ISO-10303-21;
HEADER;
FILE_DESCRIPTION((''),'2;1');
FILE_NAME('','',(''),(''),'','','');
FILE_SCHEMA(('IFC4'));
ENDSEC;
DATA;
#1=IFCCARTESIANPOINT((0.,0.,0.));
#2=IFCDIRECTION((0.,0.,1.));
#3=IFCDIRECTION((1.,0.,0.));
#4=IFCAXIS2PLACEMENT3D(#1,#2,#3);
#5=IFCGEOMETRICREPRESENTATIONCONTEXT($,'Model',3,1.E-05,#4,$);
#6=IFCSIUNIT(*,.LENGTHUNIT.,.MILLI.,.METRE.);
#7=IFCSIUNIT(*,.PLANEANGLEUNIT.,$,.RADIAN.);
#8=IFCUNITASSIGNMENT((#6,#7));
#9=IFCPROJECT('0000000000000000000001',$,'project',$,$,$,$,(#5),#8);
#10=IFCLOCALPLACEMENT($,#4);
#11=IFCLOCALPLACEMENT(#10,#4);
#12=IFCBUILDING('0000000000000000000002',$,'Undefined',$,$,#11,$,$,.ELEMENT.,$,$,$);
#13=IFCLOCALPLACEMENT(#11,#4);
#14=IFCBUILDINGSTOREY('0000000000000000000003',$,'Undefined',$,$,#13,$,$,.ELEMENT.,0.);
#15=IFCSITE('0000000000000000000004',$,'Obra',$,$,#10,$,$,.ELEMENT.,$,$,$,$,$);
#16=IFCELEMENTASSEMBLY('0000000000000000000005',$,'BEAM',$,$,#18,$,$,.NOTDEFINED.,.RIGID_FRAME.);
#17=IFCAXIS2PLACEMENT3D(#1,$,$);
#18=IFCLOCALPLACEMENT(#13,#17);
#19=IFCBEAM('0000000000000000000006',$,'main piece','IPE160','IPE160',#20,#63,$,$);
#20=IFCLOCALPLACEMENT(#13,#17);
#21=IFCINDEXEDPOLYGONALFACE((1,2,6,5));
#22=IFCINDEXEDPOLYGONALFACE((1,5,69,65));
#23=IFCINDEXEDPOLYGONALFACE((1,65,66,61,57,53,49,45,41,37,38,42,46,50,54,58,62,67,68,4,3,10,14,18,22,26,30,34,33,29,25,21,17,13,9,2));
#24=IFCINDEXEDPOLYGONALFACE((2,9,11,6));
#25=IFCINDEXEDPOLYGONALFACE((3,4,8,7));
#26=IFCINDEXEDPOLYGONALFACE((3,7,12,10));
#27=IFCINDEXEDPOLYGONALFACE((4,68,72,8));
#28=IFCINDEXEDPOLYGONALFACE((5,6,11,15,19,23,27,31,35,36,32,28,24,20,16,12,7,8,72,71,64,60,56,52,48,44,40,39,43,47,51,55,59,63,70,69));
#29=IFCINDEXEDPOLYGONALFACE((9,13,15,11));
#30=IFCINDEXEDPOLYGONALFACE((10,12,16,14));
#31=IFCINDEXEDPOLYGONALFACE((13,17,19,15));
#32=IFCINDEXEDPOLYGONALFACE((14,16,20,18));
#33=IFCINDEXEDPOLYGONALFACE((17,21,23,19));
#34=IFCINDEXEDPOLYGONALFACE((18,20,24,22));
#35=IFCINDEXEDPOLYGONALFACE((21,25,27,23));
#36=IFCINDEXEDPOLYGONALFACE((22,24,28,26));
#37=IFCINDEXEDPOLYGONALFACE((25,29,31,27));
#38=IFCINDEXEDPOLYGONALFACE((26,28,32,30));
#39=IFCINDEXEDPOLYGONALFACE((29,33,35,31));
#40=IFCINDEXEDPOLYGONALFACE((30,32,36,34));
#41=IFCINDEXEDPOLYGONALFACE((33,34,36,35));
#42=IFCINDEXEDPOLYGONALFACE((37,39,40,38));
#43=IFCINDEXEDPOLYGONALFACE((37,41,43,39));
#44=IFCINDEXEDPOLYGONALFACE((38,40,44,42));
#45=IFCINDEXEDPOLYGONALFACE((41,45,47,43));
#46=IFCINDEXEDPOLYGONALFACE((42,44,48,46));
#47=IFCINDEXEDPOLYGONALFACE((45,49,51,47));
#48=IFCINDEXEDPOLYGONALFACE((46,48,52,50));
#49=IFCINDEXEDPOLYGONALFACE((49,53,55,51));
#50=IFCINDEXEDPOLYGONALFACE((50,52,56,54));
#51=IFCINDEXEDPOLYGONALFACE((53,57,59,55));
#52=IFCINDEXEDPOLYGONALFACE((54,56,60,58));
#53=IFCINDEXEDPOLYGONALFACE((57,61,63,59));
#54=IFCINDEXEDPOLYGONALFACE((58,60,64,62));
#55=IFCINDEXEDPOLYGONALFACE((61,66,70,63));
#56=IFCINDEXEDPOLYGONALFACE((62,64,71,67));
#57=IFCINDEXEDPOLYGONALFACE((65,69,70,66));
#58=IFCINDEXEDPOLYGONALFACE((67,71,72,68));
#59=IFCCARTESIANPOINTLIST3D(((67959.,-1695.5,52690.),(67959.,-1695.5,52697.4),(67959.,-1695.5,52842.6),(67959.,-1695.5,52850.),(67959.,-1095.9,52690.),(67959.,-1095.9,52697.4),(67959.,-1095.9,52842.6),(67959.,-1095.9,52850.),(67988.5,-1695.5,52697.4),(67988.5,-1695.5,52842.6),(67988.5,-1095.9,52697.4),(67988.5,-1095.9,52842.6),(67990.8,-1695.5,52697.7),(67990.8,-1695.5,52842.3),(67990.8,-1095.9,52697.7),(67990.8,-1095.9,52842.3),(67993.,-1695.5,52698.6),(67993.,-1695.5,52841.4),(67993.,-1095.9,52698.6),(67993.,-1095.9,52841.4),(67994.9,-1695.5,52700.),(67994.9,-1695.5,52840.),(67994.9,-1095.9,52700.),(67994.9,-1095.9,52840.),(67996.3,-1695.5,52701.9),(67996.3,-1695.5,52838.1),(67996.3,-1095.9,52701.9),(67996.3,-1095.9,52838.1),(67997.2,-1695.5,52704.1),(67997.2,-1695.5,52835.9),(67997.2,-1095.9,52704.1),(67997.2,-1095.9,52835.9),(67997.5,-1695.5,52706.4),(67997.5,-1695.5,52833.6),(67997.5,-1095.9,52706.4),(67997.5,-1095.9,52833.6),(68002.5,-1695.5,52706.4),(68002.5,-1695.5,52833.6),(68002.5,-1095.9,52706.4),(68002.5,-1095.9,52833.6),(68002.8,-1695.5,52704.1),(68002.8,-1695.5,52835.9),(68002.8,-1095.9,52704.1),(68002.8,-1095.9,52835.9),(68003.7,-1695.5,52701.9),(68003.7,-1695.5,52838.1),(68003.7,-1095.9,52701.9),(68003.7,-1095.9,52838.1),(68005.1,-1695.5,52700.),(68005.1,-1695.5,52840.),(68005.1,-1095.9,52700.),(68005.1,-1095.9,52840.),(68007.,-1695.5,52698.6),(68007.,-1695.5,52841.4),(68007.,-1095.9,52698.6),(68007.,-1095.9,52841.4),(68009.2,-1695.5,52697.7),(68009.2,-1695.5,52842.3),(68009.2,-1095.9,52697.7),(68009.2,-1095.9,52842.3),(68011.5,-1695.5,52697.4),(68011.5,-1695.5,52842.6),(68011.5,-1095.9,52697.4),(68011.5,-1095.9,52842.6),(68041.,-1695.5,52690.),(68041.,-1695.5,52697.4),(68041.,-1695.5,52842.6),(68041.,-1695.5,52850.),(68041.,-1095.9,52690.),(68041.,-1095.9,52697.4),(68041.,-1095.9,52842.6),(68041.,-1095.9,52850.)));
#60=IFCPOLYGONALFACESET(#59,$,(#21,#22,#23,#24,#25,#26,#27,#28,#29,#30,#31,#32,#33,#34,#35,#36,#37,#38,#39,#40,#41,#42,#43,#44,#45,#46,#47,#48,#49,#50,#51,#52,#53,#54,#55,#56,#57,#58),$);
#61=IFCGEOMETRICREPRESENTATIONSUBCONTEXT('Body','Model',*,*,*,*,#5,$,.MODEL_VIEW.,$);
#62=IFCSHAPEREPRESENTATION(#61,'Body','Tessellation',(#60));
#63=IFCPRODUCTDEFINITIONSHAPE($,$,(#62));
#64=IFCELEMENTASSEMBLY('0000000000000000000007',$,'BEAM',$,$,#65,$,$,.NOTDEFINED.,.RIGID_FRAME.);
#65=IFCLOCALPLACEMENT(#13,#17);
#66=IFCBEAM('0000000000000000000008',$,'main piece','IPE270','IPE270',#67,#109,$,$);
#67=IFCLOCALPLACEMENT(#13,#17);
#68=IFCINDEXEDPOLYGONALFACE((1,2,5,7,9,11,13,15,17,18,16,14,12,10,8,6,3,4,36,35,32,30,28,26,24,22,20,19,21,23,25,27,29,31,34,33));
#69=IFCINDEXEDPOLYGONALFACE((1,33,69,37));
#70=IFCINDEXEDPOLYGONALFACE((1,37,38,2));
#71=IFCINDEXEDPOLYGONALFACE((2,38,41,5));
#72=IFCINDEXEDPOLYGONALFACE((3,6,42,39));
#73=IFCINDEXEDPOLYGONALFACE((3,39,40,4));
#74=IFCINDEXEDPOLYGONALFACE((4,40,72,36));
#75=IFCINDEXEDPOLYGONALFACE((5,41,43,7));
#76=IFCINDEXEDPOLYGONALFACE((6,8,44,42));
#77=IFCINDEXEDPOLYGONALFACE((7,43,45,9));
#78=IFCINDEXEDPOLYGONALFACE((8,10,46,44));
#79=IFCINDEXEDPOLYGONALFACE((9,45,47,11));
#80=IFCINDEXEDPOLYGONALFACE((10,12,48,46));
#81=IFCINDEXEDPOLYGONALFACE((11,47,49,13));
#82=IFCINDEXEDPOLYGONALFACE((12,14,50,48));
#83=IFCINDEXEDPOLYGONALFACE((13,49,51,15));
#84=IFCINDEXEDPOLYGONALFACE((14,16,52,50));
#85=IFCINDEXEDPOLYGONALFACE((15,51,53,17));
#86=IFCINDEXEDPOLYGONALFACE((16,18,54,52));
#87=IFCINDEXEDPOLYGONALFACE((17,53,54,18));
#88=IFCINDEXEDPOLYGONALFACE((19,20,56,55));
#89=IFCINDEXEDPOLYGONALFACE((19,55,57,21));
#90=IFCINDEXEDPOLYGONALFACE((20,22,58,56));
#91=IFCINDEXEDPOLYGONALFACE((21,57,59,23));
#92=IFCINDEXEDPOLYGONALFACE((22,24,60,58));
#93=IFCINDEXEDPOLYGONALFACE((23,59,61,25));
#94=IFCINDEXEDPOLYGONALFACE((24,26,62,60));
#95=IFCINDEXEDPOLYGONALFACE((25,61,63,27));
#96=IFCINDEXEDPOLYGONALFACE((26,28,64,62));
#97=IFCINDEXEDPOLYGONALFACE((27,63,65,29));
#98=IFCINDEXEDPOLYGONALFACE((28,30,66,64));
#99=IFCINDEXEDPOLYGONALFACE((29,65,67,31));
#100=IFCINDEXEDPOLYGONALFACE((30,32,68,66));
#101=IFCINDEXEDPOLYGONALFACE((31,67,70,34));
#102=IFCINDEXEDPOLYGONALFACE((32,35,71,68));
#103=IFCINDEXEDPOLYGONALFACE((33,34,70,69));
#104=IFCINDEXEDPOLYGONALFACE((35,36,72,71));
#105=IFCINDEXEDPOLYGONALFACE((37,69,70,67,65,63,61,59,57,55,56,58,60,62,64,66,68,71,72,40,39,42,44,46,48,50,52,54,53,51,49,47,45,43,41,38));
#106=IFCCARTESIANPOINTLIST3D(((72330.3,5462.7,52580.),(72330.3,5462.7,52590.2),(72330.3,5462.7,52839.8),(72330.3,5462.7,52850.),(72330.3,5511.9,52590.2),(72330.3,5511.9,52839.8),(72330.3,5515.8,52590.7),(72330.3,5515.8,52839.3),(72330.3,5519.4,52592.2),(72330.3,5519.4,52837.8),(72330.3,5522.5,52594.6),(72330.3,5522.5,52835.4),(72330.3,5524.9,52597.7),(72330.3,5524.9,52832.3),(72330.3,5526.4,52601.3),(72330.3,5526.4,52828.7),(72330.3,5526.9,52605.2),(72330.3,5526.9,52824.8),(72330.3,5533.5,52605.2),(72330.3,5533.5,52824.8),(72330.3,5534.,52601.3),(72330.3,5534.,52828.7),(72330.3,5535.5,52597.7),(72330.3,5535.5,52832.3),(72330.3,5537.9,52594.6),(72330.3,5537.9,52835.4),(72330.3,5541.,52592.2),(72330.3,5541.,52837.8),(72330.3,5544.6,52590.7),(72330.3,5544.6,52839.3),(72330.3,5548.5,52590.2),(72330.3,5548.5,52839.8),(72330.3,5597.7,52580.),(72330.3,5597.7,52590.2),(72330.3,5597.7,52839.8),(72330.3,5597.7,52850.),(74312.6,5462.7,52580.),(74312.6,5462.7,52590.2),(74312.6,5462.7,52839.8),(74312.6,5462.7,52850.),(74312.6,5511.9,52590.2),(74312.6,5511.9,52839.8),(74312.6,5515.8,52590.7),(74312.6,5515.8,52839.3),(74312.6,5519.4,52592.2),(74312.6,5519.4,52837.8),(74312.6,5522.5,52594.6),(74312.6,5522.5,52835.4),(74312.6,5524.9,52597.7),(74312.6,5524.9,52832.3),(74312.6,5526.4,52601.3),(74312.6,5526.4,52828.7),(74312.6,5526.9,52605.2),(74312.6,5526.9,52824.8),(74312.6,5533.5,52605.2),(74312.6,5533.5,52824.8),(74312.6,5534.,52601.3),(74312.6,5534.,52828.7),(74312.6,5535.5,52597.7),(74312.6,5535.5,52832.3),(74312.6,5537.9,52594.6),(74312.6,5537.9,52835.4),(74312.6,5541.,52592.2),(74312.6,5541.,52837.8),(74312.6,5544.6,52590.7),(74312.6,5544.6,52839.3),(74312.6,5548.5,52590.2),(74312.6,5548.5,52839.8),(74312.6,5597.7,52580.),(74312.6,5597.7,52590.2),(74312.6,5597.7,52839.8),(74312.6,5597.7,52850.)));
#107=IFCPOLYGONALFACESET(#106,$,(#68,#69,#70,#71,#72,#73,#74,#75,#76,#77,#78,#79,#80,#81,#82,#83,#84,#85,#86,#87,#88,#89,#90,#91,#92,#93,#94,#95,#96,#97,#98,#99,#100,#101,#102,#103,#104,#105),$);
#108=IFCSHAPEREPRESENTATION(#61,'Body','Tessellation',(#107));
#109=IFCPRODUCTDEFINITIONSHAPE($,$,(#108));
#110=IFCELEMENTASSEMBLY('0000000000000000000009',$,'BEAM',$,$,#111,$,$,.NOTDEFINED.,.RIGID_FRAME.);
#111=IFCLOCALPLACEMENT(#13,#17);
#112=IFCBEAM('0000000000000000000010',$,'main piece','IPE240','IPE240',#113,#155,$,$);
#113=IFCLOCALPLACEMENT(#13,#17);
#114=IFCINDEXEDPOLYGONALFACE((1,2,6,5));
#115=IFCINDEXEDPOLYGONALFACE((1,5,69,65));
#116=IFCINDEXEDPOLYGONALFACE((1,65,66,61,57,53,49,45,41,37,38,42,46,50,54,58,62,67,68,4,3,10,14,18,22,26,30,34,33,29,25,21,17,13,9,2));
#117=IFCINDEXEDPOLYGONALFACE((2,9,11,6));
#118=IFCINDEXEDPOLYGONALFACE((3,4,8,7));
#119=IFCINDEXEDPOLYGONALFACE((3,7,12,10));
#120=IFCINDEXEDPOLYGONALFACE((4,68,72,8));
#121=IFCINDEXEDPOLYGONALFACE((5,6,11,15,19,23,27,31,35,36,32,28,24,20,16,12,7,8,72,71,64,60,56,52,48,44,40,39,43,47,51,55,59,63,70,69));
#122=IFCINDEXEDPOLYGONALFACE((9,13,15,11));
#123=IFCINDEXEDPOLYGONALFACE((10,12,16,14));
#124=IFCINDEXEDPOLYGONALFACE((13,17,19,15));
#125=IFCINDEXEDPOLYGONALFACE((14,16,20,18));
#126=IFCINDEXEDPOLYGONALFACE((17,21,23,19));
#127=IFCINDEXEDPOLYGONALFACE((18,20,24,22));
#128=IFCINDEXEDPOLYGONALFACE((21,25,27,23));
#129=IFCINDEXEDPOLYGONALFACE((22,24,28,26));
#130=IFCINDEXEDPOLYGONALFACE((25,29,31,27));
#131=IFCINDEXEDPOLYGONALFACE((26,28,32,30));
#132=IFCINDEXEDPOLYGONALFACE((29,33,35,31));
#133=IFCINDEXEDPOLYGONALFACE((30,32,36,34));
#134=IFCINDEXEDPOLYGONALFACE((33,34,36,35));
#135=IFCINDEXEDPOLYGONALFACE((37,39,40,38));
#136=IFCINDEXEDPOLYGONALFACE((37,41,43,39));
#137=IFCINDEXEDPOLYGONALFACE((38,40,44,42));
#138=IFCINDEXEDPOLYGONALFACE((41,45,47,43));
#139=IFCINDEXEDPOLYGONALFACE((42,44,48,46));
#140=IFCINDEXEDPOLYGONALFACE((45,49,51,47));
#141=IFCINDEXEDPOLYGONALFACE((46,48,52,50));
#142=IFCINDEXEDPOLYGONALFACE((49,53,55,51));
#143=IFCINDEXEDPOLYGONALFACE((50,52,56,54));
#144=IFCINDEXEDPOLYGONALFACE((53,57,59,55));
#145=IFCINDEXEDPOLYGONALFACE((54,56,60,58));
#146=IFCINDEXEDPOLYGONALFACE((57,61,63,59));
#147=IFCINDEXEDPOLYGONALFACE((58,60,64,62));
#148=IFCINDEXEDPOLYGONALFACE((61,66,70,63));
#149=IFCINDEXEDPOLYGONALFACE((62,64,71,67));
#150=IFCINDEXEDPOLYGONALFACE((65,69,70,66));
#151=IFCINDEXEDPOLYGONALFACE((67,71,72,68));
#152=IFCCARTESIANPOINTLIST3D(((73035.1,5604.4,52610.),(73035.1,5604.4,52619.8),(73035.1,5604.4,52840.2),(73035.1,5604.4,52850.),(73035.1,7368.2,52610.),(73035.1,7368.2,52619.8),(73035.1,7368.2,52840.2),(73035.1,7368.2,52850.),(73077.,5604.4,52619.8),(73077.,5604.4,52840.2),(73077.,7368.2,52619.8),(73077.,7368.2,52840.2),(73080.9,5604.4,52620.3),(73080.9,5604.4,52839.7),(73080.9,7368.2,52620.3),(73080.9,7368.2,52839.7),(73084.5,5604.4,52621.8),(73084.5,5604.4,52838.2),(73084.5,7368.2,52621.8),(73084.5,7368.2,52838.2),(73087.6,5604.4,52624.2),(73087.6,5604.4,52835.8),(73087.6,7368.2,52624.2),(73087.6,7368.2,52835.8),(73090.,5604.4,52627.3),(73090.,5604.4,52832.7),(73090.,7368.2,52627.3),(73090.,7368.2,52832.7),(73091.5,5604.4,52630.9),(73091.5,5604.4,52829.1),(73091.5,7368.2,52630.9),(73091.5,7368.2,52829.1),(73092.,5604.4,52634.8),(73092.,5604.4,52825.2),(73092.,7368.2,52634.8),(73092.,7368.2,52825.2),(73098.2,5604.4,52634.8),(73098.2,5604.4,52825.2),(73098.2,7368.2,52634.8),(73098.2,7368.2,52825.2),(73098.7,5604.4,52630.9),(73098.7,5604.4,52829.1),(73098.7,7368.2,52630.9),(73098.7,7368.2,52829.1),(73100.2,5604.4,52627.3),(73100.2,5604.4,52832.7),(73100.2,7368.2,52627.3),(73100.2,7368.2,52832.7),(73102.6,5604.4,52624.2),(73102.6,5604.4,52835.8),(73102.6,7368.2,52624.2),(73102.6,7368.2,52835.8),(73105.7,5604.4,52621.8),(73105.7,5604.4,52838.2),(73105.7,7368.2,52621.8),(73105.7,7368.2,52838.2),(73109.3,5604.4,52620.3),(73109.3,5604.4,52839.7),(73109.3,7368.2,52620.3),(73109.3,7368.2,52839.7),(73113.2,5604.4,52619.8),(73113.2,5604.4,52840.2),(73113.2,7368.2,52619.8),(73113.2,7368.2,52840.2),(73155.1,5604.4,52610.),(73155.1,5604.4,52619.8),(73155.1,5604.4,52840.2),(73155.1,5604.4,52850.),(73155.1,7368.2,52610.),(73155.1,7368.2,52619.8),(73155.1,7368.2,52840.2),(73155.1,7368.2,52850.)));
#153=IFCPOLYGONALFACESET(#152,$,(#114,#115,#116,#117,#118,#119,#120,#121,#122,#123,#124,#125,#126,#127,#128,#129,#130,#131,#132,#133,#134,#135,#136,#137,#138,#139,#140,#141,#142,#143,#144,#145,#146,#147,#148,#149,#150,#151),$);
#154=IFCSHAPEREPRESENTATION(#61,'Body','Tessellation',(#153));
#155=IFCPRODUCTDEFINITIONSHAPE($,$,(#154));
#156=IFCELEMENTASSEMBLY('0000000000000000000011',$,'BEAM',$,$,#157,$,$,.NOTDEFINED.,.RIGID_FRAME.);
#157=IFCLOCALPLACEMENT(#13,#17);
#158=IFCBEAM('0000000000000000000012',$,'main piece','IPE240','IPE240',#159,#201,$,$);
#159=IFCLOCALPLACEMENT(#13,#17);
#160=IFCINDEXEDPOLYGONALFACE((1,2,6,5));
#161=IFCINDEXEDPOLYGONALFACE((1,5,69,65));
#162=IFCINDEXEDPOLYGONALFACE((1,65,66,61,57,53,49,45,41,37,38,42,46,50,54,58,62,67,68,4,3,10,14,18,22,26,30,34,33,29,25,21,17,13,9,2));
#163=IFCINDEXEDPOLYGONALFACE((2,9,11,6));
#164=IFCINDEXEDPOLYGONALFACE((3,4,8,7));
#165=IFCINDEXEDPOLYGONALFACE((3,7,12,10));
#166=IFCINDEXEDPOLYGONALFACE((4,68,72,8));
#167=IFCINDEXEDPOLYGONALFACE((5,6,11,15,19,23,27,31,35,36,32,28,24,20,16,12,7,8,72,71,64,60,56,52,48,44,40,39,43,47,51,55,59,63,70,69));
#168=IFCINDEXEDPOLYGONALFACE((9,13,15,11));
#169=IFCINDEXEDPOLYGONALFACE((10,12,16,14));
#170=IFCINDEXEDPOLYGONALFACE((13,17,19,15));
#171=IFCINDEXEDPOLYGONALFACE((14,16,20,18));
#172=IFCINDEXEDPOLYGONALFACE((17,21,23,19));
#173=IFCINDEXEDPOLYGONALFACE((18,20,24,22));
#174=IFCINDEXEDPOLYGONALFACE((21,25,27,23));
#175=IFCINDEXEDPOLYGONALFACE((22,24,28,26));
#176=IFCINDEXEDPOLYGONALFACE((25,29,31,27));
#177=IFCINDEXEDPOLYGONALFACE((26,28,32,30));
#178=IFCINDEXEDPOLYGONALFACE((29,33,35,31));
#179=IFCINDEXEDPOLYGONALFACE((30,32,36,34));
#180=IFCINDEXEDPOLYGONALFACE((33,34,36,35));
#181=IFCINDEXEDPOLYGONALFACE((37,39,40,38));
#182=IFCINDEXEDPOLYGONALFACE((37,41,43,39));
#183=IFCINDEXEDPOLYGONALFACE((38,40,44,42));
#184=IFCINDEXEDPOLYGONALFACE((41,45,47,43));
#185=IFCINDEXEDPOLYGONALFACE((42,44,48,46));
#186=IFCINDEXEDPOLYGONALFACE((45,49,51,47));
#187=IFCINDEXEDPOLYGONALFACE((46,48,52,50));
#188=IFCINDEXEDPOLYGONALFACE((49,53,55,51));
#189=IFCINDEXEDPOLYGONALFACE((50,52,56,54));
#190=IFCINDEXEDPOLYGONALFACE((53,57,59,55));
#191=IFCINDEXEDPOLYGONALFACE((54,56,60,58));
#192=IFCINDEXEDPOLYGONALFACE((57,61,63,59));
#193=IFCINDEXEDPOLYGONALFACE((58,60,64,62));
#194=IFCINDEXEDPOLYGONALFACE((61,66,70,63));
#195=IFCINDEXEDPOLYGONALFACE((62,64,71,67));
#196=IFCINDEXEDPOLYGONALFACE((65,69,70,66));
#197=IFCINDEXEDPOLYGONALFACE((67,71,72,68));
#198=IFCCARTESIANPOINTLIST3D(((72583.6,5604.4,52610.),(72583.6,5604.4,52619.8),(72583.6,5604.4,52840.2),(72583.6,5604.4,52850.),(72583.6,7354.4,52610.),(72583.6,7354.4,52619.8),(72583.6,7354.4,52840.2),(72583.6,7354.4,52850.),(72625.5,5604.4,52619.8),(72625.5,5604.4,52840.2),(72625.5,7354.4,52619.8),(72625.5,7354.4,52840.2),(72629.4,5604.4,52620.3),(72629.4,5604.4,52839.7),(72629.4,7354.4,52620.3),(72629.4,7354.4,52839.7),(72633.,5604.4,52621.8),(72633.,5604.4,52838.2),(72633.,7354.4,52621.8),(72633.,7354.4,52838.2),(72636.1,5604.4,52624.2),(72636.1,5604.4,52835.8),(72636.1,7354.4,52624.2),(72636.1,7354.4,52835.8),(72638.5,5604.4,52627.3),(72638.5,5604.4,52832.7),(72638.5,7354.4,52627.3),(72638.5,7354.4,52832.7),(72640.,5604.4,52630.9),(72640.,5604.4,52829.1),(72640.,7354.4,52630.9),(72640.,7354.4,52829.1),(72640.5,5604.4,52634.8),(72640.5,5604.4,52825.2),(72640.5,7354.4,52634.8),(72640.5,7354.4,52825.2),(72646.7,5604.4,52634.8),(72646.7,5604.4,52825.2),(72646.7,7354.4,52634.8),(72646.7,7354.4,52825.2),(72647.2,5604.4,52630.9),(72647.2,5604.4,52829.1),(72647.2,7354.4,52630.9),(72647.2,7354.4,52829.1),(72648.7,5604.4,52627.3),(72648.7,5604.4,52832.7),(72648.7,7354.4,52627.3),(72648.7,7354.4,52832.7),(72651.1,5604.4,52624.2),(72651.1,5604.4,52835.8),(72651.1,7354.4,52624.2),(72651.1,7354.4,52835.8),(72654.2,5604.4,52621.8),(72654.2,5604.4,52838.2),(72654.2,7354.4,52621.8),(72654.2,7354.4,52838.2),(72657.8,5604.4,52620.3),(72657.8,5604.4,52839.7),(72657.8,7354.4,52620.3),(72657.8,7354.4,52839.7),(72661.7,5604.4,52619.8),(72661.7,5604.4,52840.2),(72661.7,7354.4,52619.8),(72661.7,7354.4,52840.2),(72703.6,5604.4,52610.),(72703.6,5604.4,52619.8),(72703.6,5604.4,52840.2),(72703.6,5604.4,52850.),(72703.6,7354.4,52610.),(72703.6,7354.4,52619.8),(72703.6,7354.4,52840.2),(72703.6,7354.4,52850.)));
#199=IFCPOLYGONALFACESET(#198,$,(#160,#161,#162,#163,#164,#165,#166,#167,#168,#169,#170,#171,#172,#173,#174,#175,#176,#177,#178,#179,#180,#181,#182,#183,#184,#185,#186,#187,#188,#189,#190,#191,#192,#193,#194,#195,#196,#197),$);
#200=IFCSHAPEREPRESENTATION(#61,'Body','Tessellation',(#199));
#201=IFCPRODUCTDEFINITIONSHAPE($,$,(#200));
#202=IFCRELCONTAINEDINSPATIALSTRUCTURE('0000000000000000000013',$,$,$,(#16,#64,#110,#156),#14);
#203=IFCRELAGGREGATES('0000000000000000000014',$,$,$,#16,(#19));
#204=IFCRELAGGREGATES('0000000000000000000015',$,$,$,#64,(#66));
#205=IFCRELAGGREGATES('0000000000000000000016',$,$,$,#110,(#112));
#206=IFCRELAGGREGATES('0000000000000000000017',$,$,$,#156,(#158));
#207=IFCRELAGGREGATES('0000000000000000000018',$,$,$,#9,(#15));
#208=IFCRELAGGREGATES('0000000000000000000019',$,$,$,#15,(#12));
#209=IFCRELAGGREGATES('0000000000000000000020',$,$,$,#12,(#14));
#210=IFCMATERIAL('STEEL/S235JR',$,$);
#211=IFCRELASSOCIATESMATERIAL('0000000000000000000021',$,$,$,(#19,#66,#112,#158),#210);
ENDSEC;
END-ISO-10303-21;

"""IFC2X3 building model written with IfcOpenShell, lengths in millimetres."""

from ifc_helpers import new_model, si_unit, frame, origin_with_axes, origin_2d_with_axis, place, context, subcontext, project, spatial, i_section, extrude, material, element, aggregate, save


model = new_model("IFC2X3")

# Units and contexts
model_context = context("Model", 3, precision=1e-05, world=origin_with_axes())
body_context = subcontext(model_context, "Body", "Model", "MODEL_VIEW")
ifc_project = project(units=[si_unit("LENGTHUNIT", "METRE", prefix="MILLI"), si_unit("PLANEANGLEUNIT", "RADIAN")], contexts=[model_context])

# Site, building, storey
site_placement = place(None, origin_with_axes())
site = spatial("IfcSite", under=ifc_project, at=site_placement, Name="Obra", CompositionType="ELEMENT")
building_placement = place(site_placement, origin_with_axes())
building = spatial("IfcBuilding", under=site, at=building_placement, Name="Undefined", CompositionType="ELEMENT")
storey_placement = place(building_placement, origin_with_axes())
storey = spatial("IfcBuildingStorey", under=building, at=storey_placement, Name="Undefined", CompositionType="ELEMENT", Elevation=0.0)

# Shared definitions
ifc_material_1 = material(Name="STEEL/S235JR")

# Element assemblies, beams
assembly_1_placement = place(storey_placement, origin_with_axes())
assembly_1 = element("IfcElementAssembly", 1, at=assembly_1_placement, inside=storey, Name="BEAM", AssemblyPlace="NOTDEFINED", PredefinedType="RIGID_FRAME")
beam_1_placement = place(assembly_1_placement, frame((68000.0, -1095.9, 52770.0), z_axis=(0.0, 0.0, 1.0), x_axis=(0.0, -1.0, 0.0)))
beam_1 = element("IfcBeam", 2, at=beam_1_placement, material=ifc_material_1, Name="main piece", Description="IPE160", ObjectType="IPE160", context=body_context, shape_type="SweptSolid", body=[
    extrude(i_section(OverallWidth=82.0, OverallDepth=160.0, WebThickness=5.0, FlangeThickness=7.4, FilletRadius=9.0, at=origin_2d_with_axis()), frame((599.6, 0.0, 0.0), z_axis=(-1.0, 0.0, 0.0), x_axis=(0.0, -1.0, 0.0)), (0.0, 0.0, 1.0), 599.6),
])
aggregate(assembly_1, [beam_1])
assembly_2_placement = place(storey_placement, origin_with_axes())
assembly_2 = element("IfcElementAssembly", 3, at=assembly_2_placement, inside=storey, Name="BEAM", AssemblyPlace="NOTDEFINED", PredefinedType="RIGID_FRAME")
beam_2_placement = place(assembly_2_placement, frame((72330.3, 5530.2, 52715.0), z_axis=(0.0, 0.0, 1.0), x_axis=(1.0, 0.0, 0.0)))
beam_2 = element("IfcBeam", 4, at=beam_2_placement, material=ifc_material_1, Name="main piece", Description="IPE270", ObjectType="IPE270", context=body_context, shape_type="SweptSolid", body=[
    extrude(i_section(OverallWidth=135.0, OverallDepth=270.0, WebThickness=6.6, FlangeThickness=10.2, FilletRadius=15.0, at=origin_2d_with_axis()), frame((1982.3, 0.0, 0.0), z_axis=(-1.0, 0.0, 0.0), x_axis=(0.0, -1.0, 0.0)), (0.0, 0.0, 1.0), 1982.3),
])
aggregate(assembly_2, [beam_2])
assembly_3_placement = place(storey_placement, origin_with_axes())
assembly_3 = element("IfcElementAssembly", 5, at=assembly_3_placement, inside=storey, Name="BEAM", AssemblyPlace="NOTDEFINED", PredefinedType="RIGID_FRAME")
beam_3_placement = place(assembly_3_placement, frame((73095.1, 7368.2, 52730.0), z_axis=(0.0, 0.0, 1.0), x_axis=(0.0, -1.0, 0.0)))
beam_3 = element("IfcBeam", 6, at=beam_3_placement, material=ifc_material_1, Name="main piece", Description="IPE240", ObjectType="IPE240", context=body_context, shape_type="SweptSolid", body=[
    extrude(i_section(OverallWidth=120.0, OverallDepth=240.0, WebThickness=6.2, FlangeThickness=9.8, FilletRadius=15.0, at=origin_2d_with_axis()), frame((1763.8, 0.0, 0.0), z_axis=(-1.0, 0.0, 0.0), x_axis=(0.0, -1.0, 0.0)), (0.0, 0.0, 1.0), 1763.8),
])
aggregate(assembly_3, [beam_3])
assembly_4_placement = place(storey_placement, origin_with_axes())
assembly_4 = element("IfcElementAssembly", 7, at=assembly_4_placement, inside=storey, Name="BEAM", AssemblyPlace="NOTDEFINED", PredefinedType="RIGID_FRAME")
beam_4_placement = place(assembly_4_placement, frame((72643.6, 5604.4, 52730.0), z_axis=(0.0, 0.0, 1.0), x_axis=(0.0, 1.0, 0.0)))
beam_4 = element("IfcBeam", 8, at=beam_4_placement, material=ifc_material_1, Name="main piece", Description="IPE240", ObjectType="IPE240", context=body_context, shape_type="SweptSolid", body=[
    extrude(i_section(OverallWidth=120.0, OverallDepth=240.0, WebThickness=6.2, FlangeThickness=9.8, FilletRadius=15.0, at=origin_2d_with_axis()), frame((1750.0, 0.0, 0.0), z_axis=(-1.0, 0.0, 0.0), x_axis=(0.0, -1.0, 0.0)), (0.0, 0.0, 1.0), 1750.0),
])
aggregate(assembly_4, [beam_4])

save(model, "model.ifc")
